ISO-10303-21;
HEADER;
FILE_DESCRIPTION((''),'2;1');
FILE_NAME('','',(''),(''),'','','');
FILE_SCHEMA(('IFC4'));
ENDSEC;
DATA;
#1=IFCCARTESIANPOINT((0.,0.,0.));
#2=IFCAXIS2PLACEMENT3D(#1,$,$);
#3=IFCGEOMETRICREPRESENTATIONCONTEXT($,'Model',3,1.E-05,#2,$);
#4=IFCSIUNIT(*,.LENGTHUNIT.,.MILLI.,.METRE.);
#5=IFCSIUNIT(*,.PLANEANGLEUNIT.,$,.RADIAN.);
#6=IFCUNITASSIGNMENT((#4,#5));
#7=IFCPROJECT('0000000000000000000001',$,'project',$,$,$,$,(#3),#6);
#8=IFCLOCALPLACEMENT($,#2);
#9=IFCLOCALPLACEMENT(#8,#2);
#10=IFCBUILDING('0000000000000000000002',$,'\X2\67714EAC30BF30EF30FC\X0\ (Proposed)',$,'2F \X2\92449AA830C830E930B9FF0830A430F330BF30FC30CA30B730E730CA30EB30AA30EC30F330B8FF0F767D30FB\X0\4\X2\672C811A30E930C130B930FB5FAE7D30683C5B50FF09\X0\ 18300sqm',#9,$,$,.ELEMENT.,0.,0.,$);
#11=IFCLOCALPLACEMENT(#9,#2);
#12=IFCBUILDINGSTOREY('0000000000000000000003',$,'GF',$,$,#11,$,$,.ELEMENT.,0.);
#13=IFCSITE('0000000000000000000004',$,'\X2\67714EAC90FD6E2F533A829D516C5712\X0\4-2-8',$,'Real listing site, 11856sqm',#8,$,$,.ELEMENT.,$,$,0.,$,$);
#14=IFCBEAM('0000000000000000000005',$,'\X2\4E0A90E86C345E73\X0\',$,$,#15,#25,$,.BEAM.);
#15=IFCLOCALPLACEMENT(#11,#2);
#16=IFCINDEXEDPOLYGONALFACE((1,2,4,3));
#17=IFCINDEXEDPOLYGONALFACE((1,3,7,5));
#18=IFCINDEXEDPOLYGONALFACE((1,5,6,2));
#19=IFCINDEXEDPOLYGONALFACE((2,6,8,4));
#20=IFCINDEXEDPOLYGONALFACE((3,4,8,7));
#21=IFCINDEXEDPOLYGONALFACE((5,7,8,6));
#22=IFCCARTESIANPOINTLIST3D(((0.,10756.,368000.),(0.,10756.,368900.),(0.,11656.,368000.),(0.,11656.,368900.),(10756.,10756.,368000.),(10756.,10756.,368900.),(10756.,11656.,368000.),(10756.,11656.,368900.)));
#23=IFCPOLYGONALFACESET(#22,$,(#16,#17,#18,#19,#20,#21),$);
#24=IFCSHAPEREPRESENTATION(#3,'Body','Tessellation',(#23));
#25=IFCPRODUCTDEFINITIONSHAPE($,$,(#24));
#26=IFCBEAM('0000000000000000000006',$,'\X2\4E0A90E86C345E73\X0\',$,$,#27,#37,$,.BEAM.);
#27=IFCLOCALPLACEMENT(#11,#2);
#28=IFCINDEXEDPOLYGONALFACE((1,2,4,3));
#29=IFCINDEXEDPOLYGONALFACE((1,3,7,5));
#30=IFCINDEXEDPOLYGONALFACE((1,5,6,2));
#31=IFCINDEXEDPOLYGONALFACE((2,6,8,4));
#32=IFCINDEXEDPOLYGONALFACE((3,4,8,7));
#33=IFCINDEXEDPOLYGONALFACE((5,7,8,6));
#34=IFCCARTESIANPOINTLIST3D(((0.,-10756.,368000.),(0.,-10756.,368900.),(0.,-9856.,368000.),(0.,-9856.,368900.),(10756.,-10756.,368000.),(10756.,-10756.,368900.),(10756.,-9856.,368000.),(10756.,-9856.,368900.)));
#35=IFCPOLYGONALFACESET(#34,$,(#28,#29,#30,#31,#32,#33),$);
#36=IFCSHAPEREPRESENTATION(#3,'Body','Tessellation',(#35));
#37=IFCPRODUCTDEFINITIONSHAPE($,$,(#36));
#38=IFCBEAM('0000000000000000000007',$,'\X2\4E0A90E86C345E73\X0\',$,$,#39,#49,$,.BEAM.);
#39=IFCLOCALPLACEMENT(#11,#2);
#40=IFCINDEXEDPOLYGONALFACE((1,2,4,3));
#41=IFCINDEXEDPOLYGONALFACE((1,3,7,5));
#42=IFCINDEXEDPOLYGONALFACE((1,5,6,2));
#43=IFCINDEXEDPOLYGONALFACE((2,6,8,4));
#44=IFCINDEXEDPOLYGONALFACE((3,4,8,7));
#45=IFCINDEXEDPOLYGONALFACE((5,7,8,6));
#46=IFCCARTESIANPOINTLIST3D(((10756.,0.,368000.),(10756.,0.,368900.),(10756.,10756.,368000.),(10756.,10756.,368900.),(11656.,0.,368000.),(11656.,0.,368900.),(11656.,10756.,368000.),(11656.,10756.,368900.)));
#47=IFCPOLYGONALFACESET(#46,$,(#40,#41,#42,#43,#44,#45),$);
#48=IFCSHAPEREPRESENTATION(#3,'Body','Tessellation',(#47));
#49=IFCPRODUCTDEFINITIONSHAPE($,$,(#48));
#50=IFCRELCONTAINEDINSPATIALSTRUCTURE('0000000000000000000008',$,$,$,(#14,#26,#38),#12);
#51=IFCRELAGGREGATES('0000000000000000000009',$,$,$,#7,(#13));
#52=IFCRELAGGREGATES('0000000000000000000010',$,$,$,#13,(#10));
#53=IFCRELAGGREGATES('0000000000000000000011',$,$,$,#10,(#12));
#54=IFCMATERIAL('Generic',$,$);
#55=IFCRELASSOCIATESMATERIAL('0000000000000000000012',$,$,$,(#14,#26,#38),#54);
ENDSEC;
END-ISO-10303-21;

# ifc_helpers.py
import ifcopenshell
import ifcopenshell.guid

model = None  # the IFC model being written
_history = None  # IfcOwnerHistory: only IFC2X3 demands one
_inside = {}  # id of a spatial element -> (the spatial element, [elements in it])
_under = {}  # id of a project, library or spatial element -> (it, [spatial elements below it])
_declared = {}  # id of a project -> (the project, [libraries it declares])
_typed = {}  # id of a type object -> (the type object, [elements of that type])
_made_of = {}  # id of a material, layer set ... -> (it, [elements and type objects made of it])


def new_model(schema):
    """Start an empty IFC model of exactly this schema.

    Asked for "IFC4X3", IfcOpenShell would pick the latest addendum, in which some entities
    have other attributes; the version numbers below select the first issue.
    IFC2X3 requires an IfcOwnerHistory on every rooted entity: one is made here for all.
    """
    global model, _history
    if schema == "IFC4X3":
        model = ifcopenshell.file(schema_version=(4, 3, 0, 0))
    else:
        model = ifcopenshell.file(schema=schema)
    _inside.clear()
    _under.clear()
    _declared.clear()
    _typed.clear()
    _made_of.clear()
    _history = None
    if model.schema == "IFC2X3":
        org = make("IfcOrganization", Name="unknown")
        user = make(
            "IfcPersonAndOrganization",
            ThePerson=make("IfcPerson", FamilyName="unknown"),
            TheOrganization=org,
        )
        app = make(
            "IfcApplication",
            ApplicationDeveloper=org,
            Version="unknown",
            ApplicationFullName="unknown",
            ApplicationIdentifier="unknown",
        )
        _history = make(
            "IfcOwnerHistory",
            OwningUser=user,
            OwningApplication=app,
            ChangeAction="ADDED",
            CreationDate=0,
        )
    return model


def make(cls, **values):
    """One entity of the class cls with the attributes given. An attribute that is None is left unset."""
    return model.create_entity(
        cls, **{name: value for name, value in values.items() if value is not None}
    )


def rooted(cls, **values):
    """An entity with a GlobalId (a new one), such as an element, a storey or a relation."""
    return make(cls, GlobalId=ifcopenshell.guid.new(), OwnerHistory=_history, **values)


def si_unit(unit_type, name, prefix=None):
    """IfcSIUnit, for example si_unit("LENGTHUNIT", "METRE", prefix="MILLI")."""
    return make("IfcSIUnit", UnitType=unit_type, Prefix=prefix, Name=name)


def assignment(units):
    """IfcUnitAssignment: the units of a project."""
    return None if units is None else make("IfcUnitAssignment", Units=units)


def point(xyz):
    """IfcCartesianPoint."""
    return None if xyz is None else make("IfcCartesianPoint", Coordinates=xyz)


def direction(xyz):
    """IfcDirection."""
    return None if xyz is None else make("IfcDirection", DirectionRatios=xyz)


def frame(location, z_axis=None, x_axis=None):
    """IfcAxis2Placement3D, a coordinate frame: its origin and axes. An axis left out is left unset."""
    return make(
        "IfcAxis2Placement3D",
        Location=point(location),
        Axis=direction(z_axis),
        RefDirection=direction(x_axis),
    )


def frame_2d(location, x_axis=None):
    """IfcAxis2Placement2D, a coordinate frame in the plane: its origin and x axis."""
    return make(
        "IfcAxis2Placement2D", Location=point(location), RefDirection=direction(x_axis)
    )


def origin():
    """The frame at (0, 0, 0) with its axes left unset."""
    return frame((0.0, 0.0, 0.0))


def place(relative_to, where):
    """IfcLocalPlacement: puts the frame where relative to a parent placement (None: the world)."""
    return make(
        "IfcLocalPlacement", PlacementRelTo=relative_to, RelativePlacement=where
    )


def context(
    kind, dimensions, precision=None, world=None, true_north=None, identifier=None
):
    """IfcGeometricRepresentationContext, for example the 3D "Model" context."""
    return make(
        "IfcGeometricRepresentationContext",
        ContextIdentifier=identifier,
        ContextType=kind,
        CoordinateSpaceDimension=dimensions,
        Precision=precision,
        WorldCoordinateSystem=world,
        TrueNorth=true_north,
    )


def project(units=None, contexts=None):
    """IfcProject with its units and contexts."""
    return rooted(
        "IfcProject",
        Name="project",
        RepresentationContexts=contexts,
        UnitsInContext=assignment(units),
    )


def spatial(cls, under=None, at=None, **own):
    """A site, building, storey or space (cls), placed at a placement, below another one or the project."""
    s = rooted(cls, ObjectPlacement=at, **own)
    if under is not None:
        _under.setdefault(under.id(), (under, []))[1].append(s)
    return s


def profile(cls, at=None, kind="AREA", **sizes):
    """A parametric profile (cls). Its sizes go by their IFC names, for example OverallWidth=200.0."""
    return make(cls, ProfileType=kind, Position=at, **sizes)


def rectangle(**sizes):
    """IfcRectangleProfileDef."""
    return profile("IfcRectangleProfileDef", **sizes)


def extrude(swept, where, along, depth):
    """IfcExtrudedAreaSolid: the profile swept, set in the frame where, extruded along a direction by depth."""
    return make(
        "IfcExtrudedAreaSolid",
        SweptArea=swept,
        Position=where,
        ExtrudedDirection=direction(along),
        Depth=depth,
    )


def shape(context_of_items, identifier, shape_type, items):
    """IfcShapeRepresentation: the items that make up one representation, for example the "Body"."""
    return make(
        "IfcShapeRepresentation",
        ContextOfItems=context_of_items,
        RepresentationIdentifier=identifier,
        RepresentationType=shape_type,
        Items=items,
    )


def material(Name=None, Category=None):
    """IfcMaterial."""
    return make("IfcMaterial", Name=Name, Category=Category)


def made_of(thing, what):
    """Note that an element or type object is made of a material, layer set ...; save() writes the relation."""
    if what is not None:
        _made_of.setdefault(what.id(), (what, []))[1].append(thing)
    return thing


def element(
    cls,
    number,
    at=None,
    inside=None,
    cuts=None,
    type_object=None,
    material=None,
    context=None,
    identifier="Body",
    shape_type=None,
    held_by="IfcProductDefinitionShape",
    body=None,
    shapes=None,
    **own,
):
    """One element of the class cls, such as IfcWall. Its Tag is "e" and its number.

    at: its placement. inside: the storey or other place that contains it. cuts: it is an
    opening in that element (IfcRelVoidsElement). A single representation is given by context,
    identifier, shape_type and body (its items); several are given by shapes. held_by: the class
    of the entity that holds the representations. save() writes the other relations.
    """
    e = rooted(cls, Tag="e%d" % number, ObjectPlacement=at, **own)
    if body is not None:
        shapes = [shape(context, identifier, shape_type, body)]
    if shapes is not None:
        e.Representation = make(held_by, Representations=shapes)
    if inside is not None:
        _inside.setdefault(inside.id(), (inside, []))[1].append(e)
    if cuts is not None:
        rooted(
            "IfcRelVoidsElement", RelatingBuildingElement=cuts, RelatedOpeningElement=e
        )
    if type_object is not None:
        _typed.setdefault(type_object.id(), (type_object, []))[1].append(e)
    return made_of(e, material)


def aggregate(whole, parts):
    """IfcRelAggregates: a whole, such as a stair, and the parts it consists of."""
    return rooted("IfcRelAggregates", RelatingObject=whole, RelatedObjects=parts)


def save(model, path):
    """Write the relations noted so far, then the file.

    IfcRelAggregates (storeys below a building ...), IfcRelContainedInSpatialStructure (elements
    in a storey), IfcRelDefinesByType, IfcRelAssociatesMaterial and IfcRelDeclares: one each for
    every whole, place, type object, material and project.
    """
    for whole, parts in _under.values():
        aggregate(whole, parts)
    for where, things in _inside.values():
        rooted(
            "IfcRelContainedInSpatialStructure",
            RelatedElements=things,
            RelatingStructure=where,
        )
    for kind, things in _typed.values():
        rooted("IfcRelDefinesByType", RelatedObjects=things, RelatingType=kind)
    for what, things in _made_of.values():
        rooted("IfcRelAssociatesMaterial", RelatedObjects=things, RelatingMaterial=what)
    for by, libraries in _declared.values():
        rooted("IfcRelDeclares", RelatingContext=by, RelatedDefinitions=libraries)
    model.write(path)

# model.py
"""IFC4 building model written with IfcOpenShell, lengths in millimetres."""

from ifc_helpers import new_model, si_unit, frame, frame_2d, origin, place, context, project, spatial, rectangle, extrude, material, element, save


model = new_model("IFC4")

# Units and contexts
model_context = context("Model", 3, precision=1e-05, world=origin())
ifc_project = project(units=[si_unit("LENGTHUNIT", "METRE", prefix="MILLI"), si_unit("PLANEANGLEUNIT", "RADIAN")], contexts=[model_context])

# Site, building, storey
site_placement = place(None, origin())
site = spatial("IfcSite", under=ifc_project, at=site_placement, Name="東京都港区芝公園4-2-8", ObjectType="Real listing site, 11856sqm", CompositionType="ELEMENT", RefElevation=0.0)
building_placement = place(site_placement, origin())
building = spatial("IfcBuilding", under=site, at=building_placement, Name="東京タワー (Proposed)", ObjectType="2F 鉄骨トラス（インターナショナルオレンジ／白・4本脚ラチス・微細格子） 18300sqm", CompositionType="ELEMENT", ElevationOfRefHeight=0.0, ElevationOfTerrain=0.0)
storey_placement = place(building_placement, origin())
storey = spatial("IfcBuildingStorey", under=building, at=storey_placement, Name="GF", CompositionType="ELEMENT", Elevation=0.0)

# Shared definitions
ifc_material = material(Name="Generic")

# Beams
beam_1_placement = place(storey_placement, frame((0.0, 5378.0, 184000.0)))
element("IfcBeam", 1, at=beam_1_placement, inside=storey, material=ifc_material, Name="上部水平", PredefinedType="BEAM", context=model_context, shape_type="SweptSolid", body=[
    extrude(rectangle(XDim=10756.0, YDim=900.0, at=frame_2d((5378.0, 450.0))), frame((0.0, 5378.0, 184000.0)), (0.0, 0.0, 1.0), 900.0),
])
beam_2_placement = place(storey_placement, frame((0.0, -5378.0, 184000.0)))
element("IfcBeam", 2, at=beam_2_placement, inside=storey, material=ifc_material, Name="上部水平", PredefinedType="BEAM", context=model_context, shape_type="SweptSolid", body=[
    extrude(rectangle(XDim=10756.0, YDim=900.0, at=frame_2d((5378.0, 450.0))), frame((0.0, -5378.0, 184000.0)), (0.0, 0.0, 1.0), 900.0),
])
beam_3_placement = place(storey_placement, frame((5378.0, 0.0, 184000.0)))
element("IfcBeam", 3, at=beam_3_placement, inside=storey, material=ifc_material, Name="上部水平", PredefinedType="BEAM", context=model_context, shape_type="SweptSolid", body=[
    extrude(rectangle(XDim=900.0, YDim=10756.0, at=frame_2d((450.0, 5378.0))), frame((5378.0, 0.0, 184000.0)), (0.0, 0.0, 1.0), 900.0),
])

save(model, "model.ifc")
